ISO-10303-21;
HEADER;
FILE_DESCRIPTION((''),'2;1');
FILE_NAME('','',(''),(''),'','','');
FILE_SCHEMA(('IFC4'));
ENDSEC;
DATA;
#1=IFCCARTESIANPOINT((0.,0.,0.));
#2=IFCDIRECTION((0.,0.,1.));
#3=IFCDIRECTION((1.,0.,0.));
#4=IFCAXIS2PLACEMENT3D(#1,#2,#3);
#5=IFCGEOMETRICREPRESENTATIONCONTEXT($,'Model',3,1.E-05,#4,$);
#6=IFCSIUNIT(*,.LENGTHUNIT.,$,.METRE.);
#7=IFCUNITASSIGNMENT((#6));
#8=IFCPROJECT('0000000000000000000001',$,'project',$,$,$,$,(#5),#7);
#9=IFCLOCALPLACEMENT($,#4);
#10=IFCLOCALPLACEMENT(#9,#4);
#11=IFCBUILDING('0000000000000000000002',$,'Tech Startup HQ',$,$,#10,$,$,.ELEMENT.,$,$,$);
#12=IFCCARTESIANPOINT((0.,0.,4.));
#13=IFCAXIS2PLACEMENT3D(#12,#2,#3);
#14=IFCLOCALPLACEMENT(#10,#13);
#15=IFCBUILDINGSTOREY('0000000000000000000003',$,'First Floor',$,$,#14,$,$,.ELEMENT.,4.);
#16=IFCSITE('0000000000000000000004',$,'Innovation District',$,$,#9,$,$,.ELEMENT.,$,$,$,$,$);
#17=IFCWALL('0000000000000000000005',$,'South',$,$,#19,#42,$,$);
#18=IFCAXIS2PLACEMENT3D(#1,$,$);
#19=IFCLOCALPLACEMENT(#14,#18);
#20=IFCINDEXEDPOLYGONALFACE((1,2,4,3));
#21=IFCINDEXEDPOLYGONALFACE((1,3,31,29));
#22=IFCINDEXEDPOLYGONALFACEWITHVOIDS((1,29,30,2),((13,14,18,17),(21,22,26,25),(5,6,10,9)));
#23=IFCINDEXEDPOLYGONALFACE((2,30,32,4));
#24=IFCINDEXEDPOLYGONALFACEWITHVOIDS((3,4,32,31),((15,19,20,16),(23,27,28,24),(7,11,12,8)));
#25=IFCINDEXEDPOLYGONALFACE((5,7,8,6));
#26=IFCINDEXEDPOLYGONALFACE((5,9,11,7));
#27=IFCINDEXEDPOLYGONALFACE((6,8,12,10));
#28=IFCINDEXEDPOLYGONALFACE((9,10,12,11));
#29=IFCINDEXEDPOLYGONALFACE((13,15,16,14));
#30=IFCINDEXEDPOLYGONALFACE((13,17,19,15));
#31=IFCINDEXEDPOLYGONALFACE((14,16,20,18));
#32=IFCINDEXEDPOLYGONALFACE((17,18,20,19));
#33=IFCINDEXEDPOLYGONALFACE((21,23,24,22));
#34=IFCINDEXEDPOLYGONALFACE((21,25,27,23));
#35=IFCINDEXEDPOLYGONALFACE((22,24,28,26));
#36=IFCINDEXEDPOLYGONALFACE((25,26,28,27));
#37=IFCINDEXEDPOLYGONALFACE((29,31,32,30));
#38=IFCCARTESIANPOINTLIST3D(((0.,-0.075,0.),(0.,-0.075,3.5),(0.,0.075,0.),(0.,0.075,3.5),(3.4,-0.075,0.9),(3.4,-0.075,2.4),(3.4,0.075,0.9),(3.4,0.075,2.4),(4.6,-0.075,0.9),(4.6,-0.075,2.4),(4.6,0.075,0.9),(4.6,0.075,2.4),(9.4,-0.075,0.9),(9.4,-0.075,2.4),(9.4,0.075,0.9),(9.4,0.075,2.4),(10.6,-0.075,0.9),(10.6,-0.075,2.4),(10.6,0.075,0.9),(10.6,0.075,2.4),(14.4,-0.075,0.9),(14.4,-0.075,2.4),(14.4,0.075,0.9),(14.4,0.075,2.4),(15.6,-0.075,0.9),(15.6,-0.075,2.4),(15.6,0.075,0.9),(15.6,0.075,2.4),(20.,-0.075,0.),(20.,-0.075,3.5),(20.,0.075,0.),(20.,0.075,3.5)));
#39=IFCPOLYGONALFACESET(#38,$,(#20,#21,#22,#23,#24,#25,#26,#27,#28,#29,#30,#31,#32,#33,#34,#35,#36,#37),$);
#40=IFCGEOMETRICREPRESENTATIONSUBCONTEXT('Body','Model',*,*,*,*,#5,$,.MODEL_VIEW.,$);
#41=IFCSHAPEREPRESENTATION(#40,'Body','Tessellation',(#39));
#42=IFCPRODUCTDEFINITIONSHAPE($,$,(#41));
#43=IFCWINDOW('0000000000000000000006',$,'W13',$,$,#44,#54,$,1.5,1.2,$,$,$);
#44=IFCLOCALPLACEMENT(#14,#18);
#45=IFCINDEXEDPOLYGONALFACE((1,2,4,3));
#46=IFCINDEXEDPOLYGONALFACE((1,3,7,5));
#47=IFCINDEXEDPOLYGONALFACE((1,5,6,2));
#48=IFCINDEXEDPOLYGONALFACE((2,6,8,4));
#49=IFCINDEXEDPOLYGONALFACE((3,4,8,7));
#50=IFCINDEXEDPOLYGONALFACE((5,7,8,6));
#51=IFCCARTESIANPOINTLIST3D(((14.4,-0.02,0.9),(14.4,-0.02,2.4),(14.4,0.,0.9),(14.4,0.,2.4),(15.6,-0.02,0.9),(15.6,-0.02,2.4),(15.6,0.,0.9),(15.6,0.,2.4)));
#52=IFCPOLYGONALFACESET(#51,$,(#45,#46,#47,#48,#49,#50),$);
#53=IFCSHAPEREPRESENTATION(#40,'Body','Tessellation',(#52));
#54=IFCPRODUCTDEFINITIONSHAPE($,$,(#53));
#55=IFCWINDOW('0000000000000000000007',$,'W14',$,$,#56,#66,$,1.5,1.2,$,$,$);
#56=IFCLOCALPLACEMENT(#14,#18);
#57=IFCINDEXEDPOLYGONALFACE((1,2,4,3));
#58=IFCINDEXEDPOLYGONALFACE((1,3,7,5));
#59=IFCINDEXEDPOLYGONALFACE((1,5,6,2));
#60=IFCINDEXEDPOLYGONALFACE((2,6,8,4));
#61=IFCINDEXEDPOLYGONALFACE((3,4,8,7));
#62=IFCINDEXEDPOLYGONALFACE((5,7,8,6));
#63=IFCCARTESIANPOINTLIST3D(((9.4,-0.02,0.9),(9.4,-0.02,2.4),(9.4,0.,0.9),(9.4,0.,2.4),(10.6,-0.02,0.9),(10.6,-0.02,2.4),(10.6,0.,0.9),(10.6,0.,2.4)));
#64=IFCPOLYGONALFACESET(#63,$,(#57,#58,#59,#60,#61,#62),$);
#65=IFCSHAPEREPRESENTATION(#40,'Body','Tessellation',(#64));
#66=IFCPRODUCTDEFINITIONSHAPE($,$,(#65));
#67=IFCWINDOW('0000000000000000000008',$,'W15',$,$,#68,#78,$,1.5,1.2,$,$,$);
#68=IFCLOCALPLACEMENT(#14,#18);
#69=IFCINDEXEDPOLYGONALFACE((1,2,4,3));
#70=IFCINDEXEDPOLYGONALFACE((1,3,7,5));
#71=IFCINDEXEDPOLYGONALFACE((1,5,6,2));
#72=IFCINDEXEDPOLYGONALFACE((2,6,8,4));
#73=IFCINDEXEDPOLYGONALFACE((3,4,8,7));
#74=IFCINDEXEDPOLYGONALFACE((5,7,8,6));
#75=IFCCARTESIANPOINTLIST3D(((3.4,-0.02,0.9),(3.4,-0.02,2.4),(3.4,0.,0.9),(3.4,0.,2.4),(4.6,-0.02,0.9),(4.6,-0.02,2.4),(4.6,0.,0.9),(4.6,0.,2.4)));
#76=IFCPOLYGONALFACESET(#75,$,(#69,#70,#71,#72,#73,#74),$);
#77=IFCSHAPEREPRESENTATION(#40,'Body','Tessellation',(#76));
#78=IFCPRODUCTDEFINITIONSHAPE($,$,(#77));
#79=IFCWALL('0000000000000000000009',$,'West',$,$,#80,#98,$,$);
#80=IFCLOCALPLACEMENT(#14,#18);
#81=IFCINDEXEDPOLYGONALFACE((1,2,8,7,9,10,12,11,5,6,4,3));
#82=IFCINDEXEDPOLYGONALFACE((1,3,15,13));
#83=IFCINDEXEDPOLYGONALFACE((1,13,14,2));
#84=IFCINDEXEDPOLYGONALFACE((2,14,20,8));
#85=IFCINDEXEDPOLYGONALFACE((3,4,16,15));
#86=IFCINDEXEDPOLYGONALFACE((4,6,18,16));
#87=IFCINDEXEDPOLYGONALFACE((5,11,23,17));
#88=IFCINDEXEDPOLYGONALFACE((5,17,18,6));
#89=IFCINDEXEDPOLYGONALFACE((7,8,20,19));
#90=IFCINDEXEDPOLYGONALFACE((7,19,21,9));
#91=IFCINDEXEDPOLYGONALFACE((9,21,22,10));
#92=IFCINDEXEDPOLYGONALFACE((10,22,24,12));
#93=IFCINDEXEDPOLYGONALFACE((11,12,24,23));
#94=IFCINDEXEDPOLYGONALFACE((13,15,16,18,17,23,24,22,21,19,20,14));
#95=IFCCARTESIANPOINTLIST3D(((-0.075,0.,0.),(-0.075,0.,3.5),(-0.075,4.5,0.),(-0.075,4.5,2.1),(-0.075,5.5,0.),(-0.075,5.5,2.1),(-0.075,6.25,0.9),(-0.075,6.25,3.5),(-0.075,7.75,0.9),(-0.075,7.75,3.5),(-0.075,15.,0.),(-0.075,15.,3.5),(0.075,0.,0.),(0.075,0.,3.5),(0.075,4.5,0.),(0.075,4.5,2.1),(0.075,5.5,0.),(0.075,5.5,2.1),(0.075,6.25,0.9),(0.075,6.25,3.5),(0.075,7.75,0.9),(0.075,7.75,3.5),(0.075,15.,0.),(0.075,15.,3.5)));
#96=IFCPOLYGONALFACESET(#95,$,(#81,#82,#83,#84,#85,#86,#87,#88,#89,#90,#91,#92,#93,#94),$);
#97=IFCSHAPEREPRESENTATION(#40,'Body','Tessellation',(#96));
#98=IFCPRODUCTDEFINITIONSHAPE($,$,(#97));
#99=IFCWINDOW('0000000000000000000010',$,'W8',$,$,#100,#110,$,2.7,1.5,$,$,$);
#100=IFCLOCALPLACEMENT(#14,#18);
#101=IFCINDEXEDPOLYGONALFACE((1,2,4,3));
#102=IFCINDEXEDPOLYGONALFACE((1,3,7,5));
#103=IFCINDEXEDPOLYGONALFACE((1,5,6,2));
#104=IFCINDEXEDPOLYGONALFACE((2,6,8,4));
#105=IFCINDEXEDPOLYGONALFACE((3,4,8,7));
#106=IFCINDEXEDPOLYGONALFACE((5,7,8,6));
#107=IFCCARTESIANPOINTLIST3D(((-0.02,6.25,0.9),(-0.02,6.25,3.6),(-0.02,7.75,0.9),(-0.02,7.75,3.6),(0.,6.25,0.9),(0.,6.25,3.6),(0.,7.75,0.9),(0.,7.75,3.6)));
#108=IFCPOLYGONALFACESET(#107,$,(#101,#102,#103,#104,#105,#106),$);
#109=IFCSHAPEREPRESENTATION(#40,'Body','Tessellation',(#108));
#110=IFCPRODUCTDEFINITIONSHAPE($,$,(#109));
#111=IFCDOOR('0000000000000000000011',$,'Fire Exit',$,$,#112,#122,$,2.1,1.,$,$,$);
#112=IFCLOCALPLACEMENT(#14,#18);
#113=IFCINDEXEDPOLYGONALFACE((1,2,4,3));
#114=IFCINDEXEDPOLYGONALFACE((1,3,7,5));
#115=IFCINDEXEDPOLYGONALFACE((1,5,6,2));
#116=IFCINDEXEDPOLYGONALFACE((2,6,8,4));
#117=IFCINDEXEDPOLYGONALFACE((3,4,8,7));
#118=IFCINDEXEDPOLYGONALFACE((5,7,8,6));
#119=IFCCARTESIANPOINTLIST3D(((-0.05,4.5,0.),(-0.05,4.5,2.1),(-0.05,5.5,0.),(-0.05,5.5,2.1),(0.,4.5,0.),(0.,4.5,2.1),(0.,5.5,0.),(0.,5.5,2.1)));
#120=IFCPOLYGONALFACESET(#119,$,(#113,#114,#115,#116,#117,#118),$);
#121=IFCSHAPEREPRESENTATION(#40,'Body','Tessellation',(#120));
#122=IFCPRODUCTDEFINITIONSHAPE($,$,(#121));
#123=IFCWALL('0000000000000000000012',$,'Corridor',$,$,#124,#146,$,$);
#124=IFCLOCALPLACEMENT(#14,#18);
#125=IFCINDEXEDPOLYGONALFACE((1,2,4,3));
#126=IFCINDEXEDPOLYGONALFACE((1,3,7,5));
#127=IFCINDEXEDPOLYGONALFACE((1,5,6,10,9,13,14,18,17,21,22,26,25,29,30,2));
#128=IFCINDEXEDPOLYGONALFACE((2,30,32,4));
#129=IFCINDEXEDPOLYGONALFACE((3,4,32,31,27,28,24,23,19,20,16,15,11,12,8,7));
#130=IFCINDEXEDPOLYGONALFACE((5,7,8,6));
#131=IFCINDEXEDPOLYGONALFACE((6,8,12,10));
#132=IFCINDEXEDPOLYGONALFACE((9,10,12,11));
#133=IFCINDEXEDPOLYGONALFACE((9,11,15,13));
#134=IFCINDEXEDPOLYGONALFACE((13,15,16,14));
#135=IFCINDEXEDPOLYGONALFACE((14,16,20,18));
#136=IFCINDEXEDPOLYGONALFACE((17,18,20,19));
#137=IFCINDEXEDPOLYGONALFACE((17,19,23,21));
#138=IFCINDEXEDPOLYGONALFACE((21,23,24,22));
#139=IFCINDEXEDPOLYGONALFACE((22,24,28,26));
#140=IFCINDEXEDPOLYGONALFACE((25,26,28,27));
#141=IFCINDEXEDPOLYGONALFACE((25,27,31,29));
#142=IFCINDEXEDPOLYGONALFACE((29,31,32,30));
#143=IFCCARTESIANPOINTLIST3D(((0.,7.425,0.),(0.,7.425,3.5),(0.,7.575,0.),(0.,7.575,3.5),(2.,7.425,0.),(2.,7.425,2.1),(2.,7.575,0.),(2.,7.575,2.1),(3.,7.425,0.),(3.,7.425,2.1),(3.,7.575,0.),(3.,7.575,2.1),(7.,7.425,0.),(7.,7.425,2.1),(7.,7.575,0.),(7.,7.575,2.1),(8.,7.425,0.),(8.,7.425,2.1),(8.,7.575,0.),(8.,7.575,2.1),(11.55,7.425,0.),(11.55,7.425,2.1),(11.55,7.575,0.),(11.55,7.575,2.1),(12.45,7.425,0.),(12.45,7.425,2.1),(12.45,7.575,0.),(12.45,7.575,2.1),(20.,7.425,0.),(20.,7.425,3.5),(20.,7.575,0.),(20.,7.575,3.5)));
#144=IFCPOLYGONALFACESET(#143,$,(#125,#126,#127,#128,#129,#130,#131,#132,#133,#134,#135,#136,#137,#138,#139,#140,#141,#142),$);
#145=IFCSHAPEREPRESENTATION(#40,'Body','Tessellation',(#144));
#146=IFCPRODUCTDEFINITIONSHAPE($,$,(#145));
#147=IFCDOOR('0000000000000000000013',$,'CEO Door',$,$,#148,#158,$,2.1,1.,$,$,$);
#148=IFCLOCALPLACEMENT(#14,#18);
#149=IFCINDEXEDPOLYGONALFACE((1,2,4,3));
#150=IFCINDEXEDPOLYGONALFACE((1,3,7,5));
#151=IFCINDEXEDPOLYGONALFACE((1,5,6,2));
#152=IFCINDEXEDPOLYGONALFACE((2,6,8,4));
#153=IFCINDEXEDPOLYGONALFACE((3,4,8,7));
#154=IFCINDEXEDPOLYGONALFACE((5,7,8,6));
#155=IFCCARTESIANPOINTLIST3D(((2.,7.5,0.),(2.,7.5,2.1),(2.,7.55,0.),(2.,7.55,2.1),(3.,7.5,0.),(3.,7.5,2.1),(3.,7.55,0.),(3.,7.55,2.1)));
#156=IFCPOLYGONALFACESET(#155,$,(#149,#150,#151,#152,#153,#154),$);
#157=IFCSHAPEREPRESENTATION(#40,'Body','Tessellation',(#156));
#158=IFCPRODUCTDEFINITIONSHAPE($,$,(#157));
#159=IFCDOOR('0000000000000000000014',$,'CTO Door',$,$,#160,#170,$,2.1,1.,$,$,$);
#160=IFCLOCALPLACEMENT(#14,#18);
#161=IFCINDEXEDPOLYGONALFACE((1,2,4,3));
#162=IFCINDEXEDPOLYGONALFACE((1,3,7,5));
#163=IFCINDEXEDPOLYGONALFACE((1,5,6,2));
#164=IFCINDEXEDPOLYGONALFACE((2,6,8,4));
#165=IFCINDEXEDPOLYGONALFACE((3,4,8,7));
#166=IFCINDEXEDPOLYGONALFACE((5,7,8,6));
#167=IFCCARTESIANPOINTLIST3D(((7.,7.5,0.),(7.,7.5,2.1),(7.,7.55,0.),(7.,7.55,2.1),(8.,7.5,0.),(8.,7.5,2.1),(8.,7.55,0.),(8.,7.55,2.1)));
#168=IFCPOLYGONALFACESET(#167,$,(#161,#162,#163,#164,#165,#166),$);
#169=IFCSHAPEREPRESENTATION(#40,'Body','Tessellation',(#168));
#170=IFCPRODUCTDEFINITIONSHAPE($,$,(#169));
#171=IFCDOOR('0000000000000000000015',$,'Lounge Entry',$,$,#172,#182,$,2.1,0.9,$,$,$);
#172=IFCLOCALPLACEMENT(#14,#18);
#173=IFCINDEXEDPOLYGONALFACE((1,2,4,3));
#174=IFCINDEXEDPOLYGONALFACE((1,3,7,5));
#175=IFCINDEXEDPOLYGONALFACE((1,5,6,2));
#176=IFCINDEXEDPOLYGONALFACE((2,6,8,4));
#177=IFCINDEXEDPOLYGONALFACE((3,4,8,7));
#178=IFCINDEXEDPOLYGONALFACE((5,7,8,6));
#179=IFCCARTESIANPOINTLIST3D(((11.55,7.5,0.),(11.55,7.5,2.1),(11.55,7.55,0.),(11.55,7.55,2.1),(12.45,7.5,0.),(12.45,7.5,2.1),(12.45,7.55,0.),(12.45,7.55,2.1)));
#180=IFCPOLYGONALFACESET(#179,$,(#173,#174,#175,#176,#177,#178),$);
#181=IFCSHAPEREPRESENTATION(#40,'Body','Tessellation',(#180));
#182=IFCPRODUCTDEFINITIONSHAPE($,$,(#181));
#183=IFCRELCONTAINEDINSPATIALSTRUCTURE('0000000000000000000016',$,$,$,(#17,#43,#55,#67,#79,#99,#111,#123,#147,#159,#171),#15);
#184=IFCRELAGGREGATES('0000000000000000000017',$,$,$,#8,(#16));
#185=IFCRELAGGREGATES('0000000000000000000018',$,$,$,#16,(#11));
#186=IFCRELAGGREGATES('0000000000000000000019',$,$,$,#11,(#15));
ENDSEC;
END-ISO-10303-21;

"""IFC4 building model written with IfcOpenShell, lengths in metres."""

from ifc_helpers import new_model, si_unit, frame, origin_with_axes, place, context, subcontext, project, spatial, polyline, outline, extrude, element, fill, save


model = new_model("IFC4")

# Units and contexts
model_context = context("Model", 3, precision=1e-05, world=origin_with_axes())
body_context = subcontext(model_context, "Body", "Model", "MODEL_VIEW")
ifc_project = project(units=[si_unit("LENGTHUNIT", "METRE")], contexts=[model_context])

# Site, building, storey
site_placement = place(None, origin_with_axes())
site = spatial("IfcSite", under=ifc_project, at=site_placement, Name="Innovation District", CompositionType="ELEMENT")
building_placement = place(site_placement, origin_with_axes())
building = spatial("IfcBuilding", under=site, at=building_placement, Name="Tech Startup HQ", CompositionType="ELEMENT")
storey_placement = place(building_placement, frame((0.0, 0.0, 4.0), z_axis=(0.0, 0.0, 1.0), x_axis=(1.0, 0.0, 0.0)))
storey = spatial("IfcBuildingStorey", under=building, at=storey_placement, Name="First Floor", CompositionType="ELEMENT", Elevation=4.0)

# Wall, openings, windows
wall_1_placement = place(storey_placement, origin_with_axes())
wall_1 = element("IfcWall", 1, at=wall_1_placement, inside=storey, Name="South", context=body_context, shape_type="SweptSolid", body=[
    extrude(outline(polyline([(20.0, 0.075, 0.0), (0.0, 0.075, 0.0), (0.0, -0.075, 0.0), (20.0, -0.075, 0.0), (20.0, 0.075, 0.0)])), None, (0.0, 0.0, 1.0), 3.5),
])
opening_1_placement = place(storey_placement, origin_with_axes())
opening_1 = element("IfcOpeningElement", 2, at=opening_1_placement, inside=storey, cuts=wall_1, context=body_context, shape_type="SweptSolid", body=[
    extrude(outline(polyline([(15.6, 0.15, 0.9), (14.4, 0.15, 0.9), (14.4, -0.15, 0.9), (15.6, -0.15, 0.9), (15.6, 0.15, 0.9)])), None, (0.0, 0.0, 1.0), 1.5),
])
opening_2_placement = place(storey_placement, origin_with_axes())
opening_2 = element("IfcOpeningElement", 3, at=opening_2_placement, inside=storey, cuts=wall_1, context=body_context, shape_type="SweptSolid", body=[
    extrude(outline(polyline([(10.6, 0.15, 0.9), (9.4, 0.15, 0.9), (9.4, -0.15, 0.9), (10.6, -0.15, 0.9), (10.6, 0.15, 0.9)])), None, (0.0, 0.0, 1.0), 1.5),
])
opening_3_placement = place(storey_placement, origin_with_axes())
opening_3 = element("IfcOpeningElement", 4, at=opening_3_placement, inside=storey, cuts=wall_1, context=body_context, shape_type="SweptSolid", body=[
    extrude(outline(polyline([(4.6, 0.15, 0.9), (3.4, 0.15, 0.9), (3.4, -0.15, 0.9), (4.6, -0.15, 0.9), (4.6, 0.15, 0.9)])), None, (0.0, 0.0, 1.0), 1.5),
])
window_1_placement = place(storey_placement, origin_with_axes())
window_1 = element("IfcWindow", 5, at=window_1_placement, inside=storey, Name="W13", OverallHeight=1.5, OverallWidth=1.2, context=body_context, shape_type="SweptSolid", body=[
    extrude(outline(polyline([(15.6, 0.0, 0.9), (14.4, 0.0, 0.9), (14.4, -0.02, 0.9), (15.6, -0.02, 0.9), (15.6, 0.0, 0.9)])), None, (0.0, 0.0, 1.0), 1.5),
])
fill(opening_1, window_1)
window_2_placement = place(storey_placement, origin_with_axes())
window_2 = element("IfcWindow", 6, at=window_2_placement, inside=storey, Name="W14", OverallHeight=1.5, OverallWidth=1.2, context=body_context, shape_type="SweptSolid", body=[
    extrude(outline(polyline([(10.6, 0.0, 0.9), (9.4, 0.0, 0.9), (9.4, -0.02, 0.9), (10.6, -0.02, 0.9), (10.6, 0.0, 0.9)])), None, (0.0, 0.0, 1.0), 1.5),
])
fill(opening_2, window_2)
window_3_placement = place(storey_placement, origin_with_axes())
window_3 = element("IfcWindow", 7, at=window_3_placement, inside=storey, Name="W15", OverallHeight=1.5, OverallWidth=1.2, context=body_context, shape_type="SweptSolid", body=[
    extrude(outline(polyline([(4.6, 0.0, 0.9), (3.4, 0.0, 0.9), (3.4, -0.02, 0.9), (4.6, -0.02, 0.9), (4.6, 0.0, 0.9)])), None, (0.0, 0.0, 1.0), 1.5),
])
fill(opening_3, window_3)

# Wall, openings, window, door
wall_2_placement = place(storey_placement, origin_with_axes())
wall_2 = element("IfcWall", 8, at=wall_2_placement, inside=storey, Name="West", context=body_context, shape_type="SweptSolid", body=[
    extrude(outline(polyline([(0.075, 0.0, 0.0), (0.075, 15.0, 0.0), (-0.075, 15.0, 0.0), (-0.075, 0.0, 0.0), (0.075, 0.0, 0.0)])), None, (0.0, 0.0, 1.0), 3.5),
])
opening_4_placement = place(storey_placement, origin_with_axes())
opening_4 = element("IfcOpeningElement", 9, at=opening_4_placement, inside=storey, cuts=wall_2, context=body_context, shape_type="SweptSolid", body=[
    extrude(outline(polyline([(0.15, 6.25, 0.9), (0.15, 7.75, 0.9), (-0.15, 7.75, 0.9), (-0.15, 6.25, 0.9), (0.15, 6.25, 0.9)])), None, (0.0, 0.0, 1.0), 2.7),
])
opening_5_placement = place(storey_placement, origin_with_axes())
opening_5 = element("IfcOpeningElement", 10, at=opening_5_placement, inside=storey, cuts=wall_2, context=body_context, shape_type="SweptSolid", body=[
    extrude(outline(polyline([(0.15, 4.5, 0.0), (0.15, 5.5, 0.0), (-0.15, 5.5, 0.0), (-0.15, 4.5, 0.0), (0.15, 4.5, 0.0)])), None, (0.0, 0.0, 1.0), 2.1),
])
window_4_placement = place(storey_placement, origin_with_axes())
window_4 = element("IfcWindow", 11, at=window_4_placement, inside=storey, Name="W8", OverallHeight=2.7, OverallWidth=1.5, context=body_context, shape_type="SweptSolid", body=[
    extrude(outline(polyline([(0.0, 6.25, 0.9), (0.0, 7.75, 0.9), (-0.02, 7.75, 0.9), (-0.02, 6.25, 0.9), (0.0, 6.25, 0.9)])), None, (0.0, 0.0, 1.0), 2.7),
])
fill(opening_4, window_4)
door_1_placement = place(storey_placement, origin_with_axes())
door_1 = element("IfcDoor", 12, at=door_1_placement, inside=storey, Name="Fire Exit", OverallHeight=2.1, OverallWidth=1.0, context=body_context, shape_type="SweptSolid", body=[
    extrude(outline(polyline([(0.0, 4.5, 0.0), (0.0, 5.5, 0.0), (-0.05, 5.5, 0.0), (-0.05, 4.5, 0.0), (0.0, 4.5, 0.0)])), None, (0.0, 0.0, 1.0), 2.1),
])
fill(opening_5, door_1)

# Wall, openings, doors
wall_3_placement = place(storey_placement, origin_with_axes())
wall_3 = element("IfcWall", 13, at=wall_3_placement, inside=storey, Name="Corridor", context=body_context, shape_type="SweptSolid", body=[
    extrude(outline(polyline([(0.0, 7.425, 0.0), (20.0, 7.425, 0.0), (20.0, 7.575, 0.0), (0.0, 7.575, 0.0), (0.0, 7.425, 0.0)])), None, (0.0, 0.0, 1.0), 3.5),
])
opening_6_placement = place(storey_placement, origin_with_axes())
opening_6 = element("IfcOpeningElement", 14, at=opening_6_placement, inside=storey, cuts=wall_3, context=body_context, shape_type="SweptSolid", body=[
    extrude(outline(polyline([(2.0, 7.35, 0.0), (3.0, 7.35, 0.0), (3.0, 7.65, 0.0), (2.0, 7.65, 0.0), (2.0, 7.35, 0.0)])), None, (0.0, 0.0, 1.0), 2.1),
])
opening_7_placement = place(storey_placement, origin_with_axes())
opening_7 = element("IfcOpeningElement", 15, at=opening_7_placement, inside=storey, cuts=wall_3, context=body_context, shape_type="SweptSolid", body=[
    extrude(outline(polyline([(7.0, 7.35, 0.0), (8.0, 7.35, 0.0), (8.0, 7.65, 0.0), (7.0, 7.65, 0.0), (7.0, 7.35, 0.0)])), None, (0.0, 0.0, 1.0), 2.1),
])
opening_8_placement = place(storey_placement, origin_with_axes())
opening_8 = element("IfcOpeningElement", 16, at=opening_8_placement, inside=storey, cuts=wall_3, context=body_context, shape_type="SweptSolid", body=[
    extrude(outline(polyline([(11.55, 7.35, 0.0), (12.45, 7.35, 0.0), (12.45, 7.65, 0.0), (11.55, 7.65, 0.0), (11.55, 7.35, 0.0)])), None, (0.0, 0.0, 1.0), 2.1),
])
door_2_placement = place(storey_placement, origin_with_axes())
door_2 = element("IfcDoor", 17, at=door_2_placement, inside=storey, Name="CEO Door", OverallHeight=2.1, OverallWidth=1.0, context=body_context, shape_type="SweptSolid", body=[
    extrude(outline(polyline([(2.0, 7.5, 0.0), (3.0, 7.5, 0.0), (3.0, 7.55, 0.0), (2.0, 7.55, 0.0), (2.0, 7.5, 0.0)])), None, (0.0, 0.0, 1.0), 2.1),
])
fill(opening_6, door_2)
door_3_placement = place(storey_placement, origin_with_axes())
door_3 = element("IfcDoor", 18, at=door_3_placement, inside=storey, Name="CTO Door", OverallHeight=2.1, OverallWidth=1.0, context=body_context, shape_type="SweptSolid", body=[
    extrude(outline(polyline([(7.0, 7.5, 0.0), (8.0, 7.5, 0.0), (8.0, 7.55, 0.0), (7.0, 7.55, 0.0), (7.0, 7.5, 0.0)])), None, (0.0, 0.0, 1.0), 2.1),
])
fill(opening_7, door_3)
door_4_placement = place(storey_placement, origin_with_axes())
door_4 = element("IfcDoor", 19, at=door_4_placement, inside=storey, Name="Lounge Entry", OverallHeight=2.1, OverallWidth=0.9, context=body_context, shape_type="SweptSolid", body=[
    extrude(outline(polyline([(11.55, 7.5, 0.0), (12.45, 7.5, 0.0), (12.45, 7.55, 0.0), (11.55, 7.55, 0.0), (11.55, 7.5, 0.0)])), None, (0.0, 0.0, 1.0), 2.1),
])
fill(opening_8, door_4)

save(model, "model.ifc")
